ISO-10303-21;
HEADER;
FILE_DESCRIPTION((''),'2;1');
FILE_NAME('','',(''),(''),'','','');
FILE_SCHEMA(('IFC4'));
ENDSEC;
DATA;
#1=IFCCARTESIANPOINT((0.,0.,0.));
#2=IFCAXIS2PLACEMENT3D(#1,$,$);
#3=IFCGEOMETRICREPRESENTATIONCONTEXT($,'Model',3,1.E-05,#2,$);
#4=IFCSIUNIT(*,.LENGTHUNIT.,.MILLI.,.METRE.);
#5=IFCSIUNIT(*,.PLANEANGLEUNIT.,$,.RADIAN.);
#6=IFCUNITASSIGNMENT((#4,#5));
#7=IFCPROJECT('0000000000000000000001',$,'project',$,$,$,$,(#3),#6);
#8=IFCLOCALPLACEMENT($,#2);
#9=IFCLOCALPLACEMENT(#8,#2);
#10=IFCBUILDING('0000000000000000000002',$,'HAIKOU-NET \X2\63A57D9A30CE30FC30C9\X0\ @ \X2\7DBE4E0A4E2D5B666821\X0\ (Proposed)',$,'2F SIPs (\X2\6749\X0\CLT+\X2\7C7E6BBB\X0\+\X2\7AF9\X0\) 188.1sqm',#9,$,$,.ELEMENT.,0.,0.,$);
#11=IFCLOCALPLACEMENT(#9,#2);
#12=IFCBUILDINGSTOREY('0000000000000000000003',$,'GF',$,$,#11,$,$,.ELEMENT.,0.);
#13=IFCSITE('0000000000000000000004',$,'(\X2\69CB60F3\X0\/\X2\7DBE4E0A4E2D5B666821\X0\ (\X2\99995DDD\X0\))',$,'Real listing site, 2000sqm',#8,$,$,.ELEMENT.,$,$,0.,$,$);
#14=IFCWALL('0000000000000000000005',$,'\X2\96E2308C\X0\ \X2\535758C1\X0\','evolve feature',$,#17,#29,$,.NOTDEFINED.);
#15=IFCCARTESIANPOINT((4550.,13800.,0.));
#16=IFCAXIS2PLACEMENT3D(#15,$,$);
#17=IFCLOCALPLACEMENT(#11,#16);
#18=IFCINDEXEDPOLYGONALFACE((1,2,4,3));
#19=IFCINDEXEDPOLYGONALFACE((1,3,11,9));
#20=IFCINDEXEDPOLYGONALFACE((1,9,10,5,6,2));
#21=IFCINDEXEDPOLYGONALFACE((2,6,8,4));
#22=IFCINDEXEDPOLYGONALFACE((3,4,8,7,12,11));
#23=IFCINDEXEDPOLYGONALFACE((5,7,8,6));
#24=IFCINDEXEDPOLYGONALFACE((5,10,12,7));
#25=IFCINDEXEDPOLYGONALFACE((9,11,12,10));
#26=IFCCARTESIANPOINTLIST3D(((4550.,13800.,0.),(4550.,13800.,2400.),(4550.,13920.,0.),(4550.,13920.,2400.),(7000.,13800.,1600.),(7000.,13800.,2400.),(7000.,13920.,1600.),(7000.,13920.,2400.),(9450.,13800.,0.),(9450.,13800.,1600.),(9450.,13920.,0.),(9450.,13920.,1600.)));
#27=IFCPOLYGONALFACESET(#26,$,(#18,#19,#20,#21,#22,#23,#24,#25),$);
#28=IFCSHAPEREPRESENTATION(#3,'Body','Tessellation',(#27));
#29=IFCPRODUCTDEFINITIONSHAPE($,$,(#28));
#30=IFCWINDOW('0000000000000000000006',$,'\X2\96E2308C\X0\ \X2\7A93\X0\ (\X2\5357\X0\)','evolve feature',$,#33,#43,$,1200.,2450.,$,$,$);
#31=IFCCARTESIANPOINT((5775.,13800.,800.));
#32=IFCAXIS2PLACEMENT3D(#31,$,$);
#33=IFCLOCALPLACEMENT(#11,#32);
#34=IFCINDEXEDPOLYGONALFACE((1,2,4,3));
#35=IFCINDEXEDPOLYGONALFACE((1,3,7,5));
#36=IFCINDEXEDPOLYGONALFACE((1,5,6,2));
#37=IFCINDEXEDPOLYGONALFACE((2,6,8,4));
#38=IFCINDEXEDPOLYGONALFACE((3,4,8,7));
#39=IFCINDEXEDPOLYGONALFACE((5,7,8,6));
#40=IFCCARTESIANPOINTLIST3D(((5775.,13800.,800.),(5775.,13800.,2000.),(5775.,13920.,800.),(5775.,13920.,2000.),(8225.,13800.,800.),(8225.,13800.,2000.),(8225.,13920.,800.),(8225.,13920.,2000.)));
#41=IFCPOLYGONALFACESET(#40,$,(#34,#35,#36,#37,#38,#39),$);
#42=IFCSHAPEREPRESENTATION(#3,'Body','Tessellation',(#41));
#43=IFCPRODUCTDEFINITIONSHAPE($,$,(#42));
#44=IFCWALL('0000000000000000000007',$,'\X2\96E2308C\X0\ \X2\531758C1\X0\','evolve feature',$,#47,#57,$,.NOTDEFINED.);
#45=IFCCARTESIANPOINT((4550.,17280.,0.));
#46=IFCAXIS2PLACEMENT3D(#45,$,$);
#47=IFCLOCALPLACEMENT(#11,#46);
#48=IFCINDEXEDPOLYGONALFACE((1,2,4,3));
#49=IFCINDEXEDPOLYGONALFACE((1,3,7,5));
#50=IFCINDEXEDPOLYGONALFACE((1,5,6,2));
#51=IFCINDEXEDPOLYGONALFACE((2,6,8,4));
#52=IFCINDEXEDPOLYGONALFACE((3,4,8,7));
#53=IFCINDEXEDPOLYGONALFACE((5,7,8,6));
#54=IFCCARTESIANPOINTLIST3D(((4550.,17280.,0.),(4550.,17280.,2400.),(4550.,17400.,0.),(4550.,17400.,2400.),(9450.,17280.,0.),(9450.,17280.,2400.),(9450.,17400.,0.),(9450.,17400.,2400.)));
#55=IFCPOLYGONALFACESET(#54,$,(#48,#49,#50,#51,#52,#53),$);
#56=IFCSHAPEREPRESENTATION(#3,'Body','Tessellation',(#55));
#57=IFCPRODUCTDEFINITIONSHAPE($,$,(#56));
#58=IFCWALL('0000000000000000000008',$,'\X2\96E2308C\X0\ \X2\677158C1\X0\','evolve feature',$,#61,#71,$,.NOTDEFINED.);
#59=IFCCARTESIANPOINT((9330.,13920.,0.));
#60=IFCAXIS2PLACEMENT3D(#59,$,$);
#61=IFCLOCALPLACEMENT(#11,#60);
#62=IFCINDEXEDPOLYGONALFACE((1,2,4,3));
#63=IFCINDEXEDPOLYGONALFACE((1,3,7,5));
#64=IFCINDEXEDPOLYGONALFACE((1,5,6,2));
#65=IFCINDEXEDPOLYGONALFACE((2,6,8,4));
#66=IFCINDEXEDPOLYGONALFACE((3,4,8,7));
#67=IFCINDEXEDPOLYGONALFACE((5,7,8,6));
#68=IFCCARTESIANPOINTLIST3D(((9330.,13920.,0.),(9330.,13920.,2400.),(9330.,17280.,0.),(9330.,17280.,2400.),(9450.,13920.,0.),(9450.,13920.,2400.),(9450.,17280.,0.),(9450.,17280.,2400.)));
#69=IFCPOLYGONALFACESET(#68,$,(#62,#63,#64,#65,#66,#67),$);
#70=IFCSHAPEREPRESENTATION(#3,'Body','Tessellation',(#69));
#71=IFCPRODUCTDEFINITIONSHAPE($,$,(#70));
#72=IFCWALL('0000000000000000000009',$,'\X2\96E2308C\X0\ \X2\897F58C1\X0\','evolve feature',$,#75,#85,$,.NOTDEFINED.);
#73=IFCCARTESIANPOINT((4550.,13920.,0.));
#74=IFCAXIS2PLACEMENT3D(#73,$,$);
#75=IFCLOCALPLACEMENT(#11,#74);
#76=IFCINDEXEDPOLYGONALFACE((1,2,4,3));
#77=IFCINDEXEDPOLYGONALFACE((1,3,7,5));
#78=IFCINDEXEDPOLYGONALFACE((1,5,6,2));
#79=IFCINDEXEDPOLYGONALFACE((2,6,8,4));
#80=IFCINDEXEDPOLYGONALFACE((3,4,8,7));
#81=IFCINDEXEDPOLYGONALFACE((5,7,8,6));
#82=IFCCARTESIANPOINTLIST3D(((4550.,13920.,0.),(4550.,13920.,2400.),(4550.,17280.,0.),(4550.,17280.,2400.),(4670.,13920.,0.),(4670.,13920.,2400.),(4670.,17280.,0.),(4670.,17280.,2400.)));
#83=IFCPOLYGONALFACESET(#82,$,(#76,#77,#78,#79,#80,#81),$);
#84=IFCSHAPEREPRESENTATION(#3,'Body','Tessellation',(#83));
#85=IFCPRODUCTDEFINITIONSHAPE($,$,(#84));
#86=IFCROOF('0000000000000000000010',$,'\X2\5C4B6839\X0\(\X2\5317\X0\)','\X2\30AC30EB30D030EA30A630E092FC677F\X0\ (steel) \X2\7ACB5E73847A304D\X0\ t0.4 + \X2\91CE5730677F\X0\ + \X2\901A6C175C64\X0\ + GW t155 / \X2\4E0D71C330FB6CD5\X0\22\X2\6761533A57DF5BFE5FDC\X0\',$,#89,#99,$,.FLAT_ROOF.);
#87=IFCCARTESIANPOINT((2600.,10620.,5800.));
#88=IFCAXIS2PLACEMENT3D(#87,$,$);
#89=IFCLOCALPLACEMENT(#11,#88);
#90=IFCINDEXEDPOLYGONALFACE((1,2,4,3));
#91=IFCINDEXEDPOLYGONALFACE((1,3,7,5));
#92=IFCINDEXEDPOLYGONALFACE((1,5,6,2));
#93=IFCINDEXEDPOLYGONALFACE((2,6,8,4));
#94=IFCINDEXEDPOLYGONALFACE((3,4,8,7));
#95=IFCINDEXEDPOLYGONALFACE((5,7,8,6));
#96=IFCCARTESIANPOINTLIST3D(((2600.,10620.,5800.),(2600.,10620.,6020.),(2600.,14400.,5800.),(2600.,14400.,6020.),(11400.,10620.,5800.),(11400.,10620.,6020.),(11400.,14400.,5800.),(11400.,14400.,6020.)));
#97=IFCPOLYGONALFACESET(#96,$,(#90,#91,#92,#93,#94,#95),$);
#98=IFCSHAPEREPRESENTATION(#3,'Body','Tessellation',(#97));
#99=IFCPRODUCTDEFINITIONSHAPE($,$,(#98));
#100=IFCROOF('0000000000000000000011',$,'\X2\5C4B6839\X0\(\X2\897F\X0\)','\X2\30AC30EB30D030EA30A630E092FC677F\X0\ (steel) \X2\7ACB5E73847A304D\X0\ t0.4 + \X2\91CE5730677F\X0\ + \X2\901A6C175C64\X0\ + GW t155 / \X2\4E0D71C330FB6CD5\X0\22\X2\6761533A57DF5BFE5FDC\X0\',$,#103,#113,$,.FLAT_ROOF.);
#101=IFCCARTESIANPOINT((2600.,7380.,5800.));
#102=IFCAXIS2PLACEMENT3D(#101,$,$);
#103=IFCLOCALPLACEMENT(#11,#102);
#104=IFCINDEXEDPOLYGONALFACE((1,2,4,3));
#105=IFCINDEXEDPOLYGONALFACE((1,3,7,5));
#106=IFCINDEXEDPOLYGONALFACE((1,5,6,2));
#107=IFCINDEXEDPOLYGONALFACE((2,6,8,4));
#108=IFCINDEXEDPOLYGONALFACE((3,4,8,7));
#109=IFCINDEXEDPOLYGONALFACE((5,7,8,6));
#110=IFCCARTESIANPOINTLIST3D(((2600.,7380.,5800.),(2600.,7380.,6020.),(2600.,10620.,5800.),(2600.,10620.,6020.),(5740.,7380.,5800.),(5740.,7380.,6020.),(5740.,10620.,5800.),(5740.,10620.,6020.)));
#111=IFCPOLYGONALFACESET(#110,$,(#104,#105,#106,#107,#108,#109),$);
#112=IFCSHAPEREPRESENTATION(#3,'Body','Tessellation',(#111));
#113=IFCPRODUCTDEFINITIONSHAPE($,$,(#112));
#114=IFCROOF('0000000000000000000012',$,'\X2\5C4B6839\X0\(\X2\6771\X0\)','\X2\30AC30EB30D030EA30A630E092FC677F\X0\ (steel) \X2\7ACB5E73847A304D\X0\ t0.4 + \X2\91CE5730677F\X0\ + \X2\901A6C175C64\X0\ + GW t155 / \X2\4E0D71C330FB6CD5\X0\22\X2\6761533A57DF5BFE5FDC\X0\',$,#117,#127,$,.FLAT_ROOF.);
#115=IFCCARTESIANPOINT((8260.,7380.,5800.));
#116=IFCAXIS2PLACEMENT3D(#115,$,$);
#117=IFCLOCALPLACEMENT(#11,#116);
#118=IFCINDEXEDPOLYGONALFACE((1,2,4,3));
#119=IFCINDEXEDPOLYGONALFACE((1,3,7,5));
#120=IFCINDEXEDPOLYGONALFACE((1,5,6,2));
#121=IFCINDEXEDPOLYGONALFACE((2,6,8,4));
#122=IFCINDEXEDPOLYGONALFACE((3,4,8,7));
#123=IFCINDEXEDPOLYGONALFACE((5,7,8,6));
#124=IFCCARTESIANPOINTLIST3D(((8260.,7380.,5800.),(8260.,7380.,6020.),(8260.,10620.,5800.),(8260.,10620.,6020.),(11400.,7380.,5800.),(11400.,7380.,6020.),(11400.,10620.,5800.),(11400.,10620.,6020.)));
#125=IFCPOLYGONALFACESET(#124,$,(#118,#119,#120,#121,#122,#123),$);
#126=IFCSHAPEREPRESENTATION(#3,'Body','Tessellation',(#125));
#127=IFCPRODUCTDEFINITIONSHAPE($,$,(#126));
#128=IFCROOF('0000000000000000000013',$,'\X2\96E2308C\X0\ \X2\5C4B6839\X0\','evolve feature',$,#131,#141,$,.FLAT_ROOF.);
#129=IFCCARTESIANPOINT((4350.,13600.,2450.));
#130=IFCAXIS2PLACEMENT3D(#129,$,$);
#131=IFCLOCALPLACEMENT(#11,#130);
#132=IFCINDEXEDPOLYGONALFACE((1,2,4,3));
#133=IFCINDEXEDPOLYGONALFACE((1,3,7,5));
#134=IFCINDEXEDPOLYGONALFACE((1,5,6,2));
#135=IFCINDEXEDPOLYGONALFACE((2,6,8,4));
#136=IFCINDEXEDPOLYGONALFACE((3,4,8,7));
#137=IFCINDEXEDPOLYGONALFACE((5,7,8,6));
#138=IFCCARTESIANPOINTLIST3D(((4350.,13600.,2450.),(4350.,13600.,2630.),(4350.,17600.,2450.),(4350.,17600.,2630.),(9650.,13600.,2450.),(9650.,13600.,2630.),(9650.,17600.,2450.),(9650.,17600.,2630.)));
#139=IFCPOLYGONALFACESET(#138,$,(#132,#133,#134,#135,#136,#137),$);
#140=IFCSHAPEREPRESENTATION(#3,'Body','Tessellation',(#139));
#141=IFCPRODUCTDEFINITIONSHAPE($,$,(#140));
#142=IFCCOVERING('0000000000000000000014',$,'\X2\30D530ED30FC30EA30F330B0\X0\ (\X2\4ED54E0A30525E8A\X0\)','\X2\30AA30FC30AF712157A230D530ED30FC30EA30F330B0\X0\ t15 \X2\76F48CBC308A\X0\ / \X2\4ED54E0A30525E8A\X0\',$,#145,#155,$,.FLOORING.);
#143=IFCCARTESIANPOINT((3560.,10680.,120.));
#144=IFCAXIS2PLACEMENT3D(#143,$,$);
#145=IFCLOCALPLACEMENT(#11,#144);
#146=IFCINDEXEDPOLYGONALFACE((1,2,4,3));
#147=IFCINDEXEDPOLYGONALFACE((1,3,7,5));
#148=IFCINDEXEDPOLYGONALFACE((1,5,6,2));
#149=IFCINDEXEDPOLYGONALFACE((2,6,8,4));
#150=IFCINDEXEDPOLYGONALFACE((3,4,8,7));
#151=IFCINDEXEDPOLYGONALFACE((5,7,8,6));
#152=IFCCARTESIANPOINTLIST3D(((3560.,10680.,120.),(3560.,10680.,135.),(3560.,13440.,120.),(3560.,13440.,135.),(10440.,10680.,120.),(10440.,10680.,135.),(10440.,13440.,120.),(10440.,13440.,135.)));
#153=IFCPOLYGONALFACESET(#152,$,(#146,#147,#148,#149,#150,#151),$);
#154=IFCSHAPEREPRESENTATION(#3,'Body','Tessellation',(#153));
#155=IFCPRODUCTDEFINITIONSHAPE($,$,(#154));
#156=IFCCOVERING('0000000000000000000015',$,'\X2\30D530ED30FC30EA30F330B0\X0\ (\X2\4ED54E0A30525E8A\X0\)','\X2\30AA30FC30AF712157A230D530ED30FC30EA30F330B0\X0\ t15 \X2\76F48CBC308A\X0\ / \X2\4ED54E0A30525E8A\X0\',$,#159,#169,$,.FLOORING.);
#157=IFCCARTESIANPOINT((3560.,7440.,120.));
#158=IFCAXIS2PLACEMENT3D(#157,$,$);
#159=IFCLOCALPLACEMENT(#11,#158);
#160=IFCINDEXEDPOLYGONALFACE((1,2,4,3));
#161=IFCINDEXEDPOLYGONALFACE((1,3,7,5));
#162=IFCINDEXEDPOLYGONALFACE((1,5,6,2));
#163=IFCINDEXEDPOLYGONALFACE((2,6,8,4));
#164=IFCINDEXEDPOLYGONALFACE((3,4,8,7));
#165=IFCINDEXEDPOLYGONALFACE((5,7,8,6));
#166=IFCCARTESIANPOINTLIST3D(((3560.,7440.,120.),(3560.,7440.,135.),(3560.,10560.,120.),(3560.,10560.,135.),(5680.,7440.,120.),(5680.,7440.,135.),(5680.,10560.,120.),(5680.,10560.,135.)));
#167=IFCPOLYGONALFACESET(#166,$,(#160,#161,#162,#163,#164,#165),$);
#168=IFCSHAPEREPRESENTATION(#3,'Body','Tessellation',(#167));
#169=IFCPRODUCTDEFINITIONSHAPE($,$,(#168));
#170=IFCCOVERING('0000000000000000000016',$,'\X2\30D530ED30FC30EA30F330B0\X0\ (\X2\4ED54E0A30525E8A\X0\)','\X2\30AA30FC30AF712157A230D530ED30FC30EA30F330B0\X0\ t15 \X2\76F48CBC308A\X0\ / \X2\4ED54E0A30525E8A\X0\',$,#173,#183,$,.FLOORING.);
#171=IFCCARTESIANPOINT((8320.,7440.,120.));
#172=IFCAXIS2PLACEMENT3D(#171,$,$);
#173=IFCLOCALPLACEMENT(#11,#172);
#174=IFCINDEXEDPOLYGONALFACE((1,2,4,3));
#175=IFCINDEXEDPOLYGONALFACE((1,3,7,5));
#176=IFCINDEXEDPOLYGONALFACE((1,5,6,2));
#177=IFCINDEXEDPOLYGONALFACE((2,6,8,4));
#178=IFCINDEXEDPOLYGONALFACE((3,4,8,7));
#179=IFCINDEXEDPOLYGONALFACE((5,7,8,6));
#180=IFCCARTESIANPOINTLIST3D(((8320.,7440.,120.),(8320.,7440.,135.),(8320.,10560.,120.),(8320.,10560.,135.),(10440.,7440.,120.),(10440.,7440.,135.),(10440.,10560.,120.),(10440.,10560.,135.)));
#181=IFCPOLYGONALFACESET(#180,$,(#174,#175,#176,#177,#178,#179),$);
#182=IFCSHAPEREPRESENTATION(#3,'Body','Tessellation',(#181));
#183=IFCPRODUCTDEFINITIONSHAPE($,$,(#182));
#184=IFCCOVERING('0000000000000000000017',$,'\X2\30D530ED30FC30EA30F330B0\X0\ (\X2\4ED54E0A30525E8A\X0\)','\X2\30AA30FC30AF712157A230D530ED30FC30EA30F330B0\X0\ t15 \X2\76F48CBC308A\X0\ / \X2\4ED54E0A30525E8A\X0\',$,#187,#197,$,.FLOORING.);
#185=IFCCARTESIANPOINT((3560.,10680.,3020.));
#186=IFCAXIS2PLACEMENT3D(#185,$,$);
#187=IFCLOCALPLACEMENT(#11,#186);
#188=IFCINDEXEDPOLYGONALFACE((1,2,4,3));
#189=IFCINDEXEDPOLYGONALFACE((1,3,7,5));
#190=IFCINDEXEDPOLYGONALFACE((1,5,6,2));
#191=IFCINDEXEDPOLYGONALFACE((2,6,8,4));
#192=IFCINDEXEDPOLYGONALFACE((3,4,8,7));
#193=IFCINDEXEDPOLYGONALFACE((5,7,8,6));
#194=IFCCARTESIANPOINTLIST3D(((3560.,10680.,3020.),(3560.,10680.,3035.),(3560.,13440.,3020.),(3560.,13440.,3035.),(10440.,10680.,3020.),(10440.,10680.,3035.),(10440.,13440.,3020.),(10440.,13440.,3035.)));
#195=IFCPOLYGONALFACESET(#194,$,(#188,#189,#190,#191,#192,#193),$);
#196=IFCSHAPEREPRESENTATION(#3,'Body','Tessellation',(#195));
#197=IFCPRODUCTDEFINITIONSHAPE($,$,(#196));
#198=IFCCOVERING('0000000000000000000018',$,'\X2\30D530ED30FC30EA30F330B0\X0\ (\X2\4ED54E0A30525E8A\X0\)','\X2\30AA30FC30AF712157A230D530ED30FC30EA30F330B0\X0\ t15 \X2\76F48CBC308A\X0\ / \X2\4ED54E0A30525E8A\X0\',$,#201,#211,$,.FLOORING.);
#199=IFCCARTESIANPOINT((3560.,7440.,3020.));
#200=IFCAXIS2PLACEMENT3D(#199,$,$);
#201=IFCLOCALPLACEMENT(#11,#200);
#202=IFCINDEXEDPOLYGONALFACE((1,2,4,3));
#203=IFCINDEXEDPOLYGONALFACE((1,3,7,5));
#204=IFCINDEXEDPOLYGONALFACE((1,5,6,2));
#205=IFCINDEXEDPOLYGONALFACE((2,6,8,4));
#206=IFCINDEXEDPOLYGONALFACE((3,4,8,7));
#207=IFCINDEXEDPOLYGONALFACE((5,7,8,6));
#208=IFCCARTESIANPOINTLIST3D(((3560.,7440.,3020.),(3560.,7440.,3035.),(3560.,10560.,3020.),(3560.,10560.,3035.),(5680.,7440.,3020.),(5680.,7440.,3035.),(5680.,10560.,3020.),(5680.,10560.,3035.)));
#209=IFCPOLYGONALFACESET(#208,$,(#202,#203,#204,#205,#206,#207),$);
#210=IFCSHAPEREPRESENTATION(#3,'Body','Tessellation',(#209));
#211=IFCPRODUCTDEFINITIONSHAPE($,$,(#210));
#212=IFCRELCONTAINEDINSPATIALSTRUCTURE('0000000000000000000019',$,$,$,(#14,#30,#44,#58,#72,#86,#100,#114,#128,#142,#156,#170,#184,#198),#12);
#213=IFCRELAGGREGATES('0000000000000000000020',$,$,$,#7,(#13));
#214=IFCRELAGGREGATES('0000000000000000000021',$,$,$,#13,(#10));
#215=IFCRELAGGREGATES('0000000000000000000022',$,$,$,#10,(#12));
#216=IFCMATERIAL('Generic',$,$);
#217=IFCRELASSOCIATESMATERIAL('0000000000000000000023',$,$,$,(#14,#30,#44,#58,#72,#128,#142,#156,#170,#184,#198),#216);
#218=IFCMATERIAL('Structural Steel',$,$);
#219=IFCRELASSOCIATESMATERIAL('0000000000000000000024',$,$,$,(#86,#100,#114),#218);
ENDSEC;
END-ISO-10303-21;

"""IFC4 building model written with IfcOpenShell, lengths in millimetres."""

from ifc_helpers import new_model, si_unit, frame, frame_2d, origin, place, context, project, spatial, rectangle, extrude, material, element, fill, save


model = new_model("IFC4")

# Units and contexts
model_context = context("Model", 3, precision=1e-05, world=origin())
ifc_project = project(units=[si_unit("LENGTHUNIT", "METRE", prefix="MILLI"), si_unit("PLANEANGLEUNIT", "RADIAN")], contexts=[model_context])

# Site, building, storey
site_placement = place(None, origin())
site = spatial("IfcSite", under=ifc_project, at=site_placement, Name="(構想/綾上中学校 (香川))", ObjectType="Real listing site, 2000sqm", CompositionType="ELEMENT", RefElevation=0.0)
building_placement = place(site_placement, origin())
building = spatial("IfcBuilding", under=site, at=building_placement, Name="HAIKOU-NET 接続ノード @ 綾上中学校 (Proposed)", ObjectType="2F SIPs (杉CLT+籾殻+竹) 188.1sqm", CompositionType="ELEMENT", ElevationOfRefHeight=0.0, ElevationOfTerrain=0.0)
storey_placement = place(building_placement, origin())
storey = spatial("IfcBuildingStorey", under=building, at=storey_placement, Name="GF", CompositionType="ELEMENT", Elevation=0.0)

# Shared definitions
ifc_material_1 = material(Name="Generic")

# Wall, opening, window
wall_1_placement = place(storey_placement, frame((4550.0, 13800.0, 0.0)))
wall_1 = element("IfcWall", 1, at=wall_1_placement, inside=storey, material=ifc_material_1, Name="離れ 南壁", Description="evolve feature", PredefinedType="NOTDEFINED", context=model_context, shape_type="SweptSolid", body=[
    extrude(rectangle(XDim=4900.0, YDim=120.0, at=frame_2d((2450.0, 60.0))), frame((4550.0, 13800.0, 0.0)), (0.0, 0.0, 1.0), 2400.0),
])
opening_1_placement = place(storey_placement, frame((5775.0, 13800.0, 800.0)))
opening_1 = element("IfcOpeningElement", 2, at=opening_1_placement, cuts=wall_1, PredefinedType="NOTDEFINED", context=model_context, shape_type="SweptSolid", body=[
    extrude(rectangle(XDim=2450.0, YDim=120.0, at=frame_2d((1225.0, 60.0))), frame((5775.0, 13800.0, 800.0)), (0.0, 0.0, 1.0), 1200.0),
])
window_1_placement = place(storey_placement, frame((5775.0, 13800.0, 800.0)))
window_1 = element("IfcWindow", 3, at=window_1_placement, inside=storey, material=ifc_material_1, Name="離れ 窓 (南)", Description="evolve feature", OverallHeight=1200.0, OverallWidth=2450.0, context=model_context, shape_type="SweptSolid", body=[
    extrude(rectangle(XDim=2450.0, YDim=120.0, at=frame_2d((1225.0, 60.0))), frame((5775.0, 13800.0, 800.0)), (0.0, 0.0, 1.0), 1200.0),
])
fill(opening_1, window_1)

# Walls
wall_2_placement = place(storey_placement, frame((4550.0, 17280.0, 0.0)))
element("IfcWall", 4, at=wall_2_placement, inside=storey, material=ifc_material_1, Name="離れ 北壁", Description="evolve feature", PredefinedType="NOTDEFINED", context=model_context, shape_type="SweptSolid", body=[
    extrude(rectangle(XDim=4900.0, YDim=120.0, at=frame_2d((2450.0, 60.0))), frame((4550.0, 17280.0, 0.0)), (0.0, 0.0, 1.0), 2400.0),
])
wall_3_placement = place(storey_placement, frame((9330.0, 13920.0, 0.0)))
element("IfcWall", 5, at=wall_3_placement, inside=storey, material=ifc_material_1, Name="離れ 東壁", Description="evolve feature", PredefinedType="NOTDEFINED", context=model_context, shape_type="SweptSolid", body=[
    extrude(rectangle(XDim=120.0, YDim=3360.0, at=frame_2d((60.0, 1680.0))), frame((9330.0, 13920.0, 0.0)), (0.0, 0.0, 1.0), 2400.0),
])
wall_4_placement = place(storey_placement, frame((4550.0, 13920.0, 0.0)))
element("IfcWall", 6, at=wall_4_placement, inside=storey, material=ifc_material_1, Name="離れ 西壁", Description="evolve feature", PredefinedType="NOTDEFINED", context=model_context, shape_type="SweptSolid", body=[
    extrude(rectangle(XDim=120.0, YDim=3360.0, at=frame_2d((60.0, 1680.0))), frame((4550.0, 13920.0, 0.0)), (0.0, 0.0, 1.0), 2400.0),
])

# Roofs
ifc_material_2 = material(Name="Structural Steel")
for number, where, name in (
    (7, (2600.0, 10620.0, 5800.0), "屋根(北)"),
):
    element("IfcRoof", number, at=place(storey_placement, frame(where)), inside=storey, material=ifc_material_2, Name=name, Description="ガルバリウム鋼板 (steel) 立平葺き t0.4 + 野地板 + 通気層 + GW t155 / 不燃・法22条区域対応", PredefinedType="FLAT_ROOF", context=model_context, shape_type="SweptSolid", body=[
        extrude(rectangle(XDim=8800.0, YDim=3780.0, at=frame_2d((4400.0, 1890.0))), frame((2600.0, 10620.0, 5800.0)), (0.0, 0.0, 1.0), 220.0),
    ])
roof_1_placement = place(storey_placement, frame((2600.0, 7380.0, 5800.0)))
element("IfcRoof", 8, at=roof_1_placement, inside=storey, material=ifc_material_2, Name="屋根(西)", Description="ガルバリウム鋼板 (steel) 立平葺き t0.4 + 野地板 + 通気層 + GW t155 / 不燃・法22条区域対応", PredefinedType="FLAT_ROOF", context=model_context, shape_type="SweptSolid", body=[
    extrude(rectangle(XDim=3140.0, YDim=3240.0, at=frame_2d((1570.0, 1620.0))), frame((2600.0, 7380.0, 5800.0)), (0.0, 0.0, 1.0), 220.0),
])
roof_2_placement = place(storey_placement, frame((8260.0, 7380.0, 5800.0)))
element("IfcRoof", 9, at=roof_2_placement, inside=storey, material=ifc_material_2, Name="屋根(東)", Description="ガルバリウム鋼板 (steel) 立平葺き t0.4 + 野地板 + 通気層 + GW t155 / 不燃・法22条区域対応", PredefinedType="FLAT_ROOF", context=model_context, shape_type="SweptSolid", body=[
    extrude(rectangle(XDim=3140.0, YDim=3240.0, at=frame_2d((1570.0, 1620.0))), frame((8260.0, 7380.0, 5800.0)), (0.0, 0.0, 1.0), 220.0),
])
roof_3_placement = place(storey_placement, frame((4350.0, 13600.0, 2450.0)))
element("IfcRoof", 10, at=roof_3_placement, inside=storey, material=ifc_material_1, Name="離れ 屋根", Description="evolve feature", PredefinedType="FLAT_ROOF", context=model_context, shape_type="SweptSolid", body=[
    extrude(rectangle(XDim=5300.0, YDim=4000.0, at=frame_2d((2650.0, 2000.0))), frame((4350.0, 13600.0, 2450.0)), (0.0, 0.0, 1.0), 180.0),
])

# Coverings
covering_1_placement = place(storey_placement, frame((3560.0, 10680.0, 120.0)))
element("IfcCovering", 11, at=covering_1_placement, inside=storey, material=ifc_material_1, Name="フローリング (仕上げ床)", Description="オーク無垢フローリング t15 直貼り / 仕上げ床", PredefinedType="FLOORING", context=model_context, shape_type="SweptSolid", body=[
    extrude(rectangle(XDim=6880.0, YDim=2760.0, at=frame_2d((3440.0, 1380.0))), frame((3560.0, 10680.0, 120.0)), (0.0, 0.0, 1.0), 15.0),
])
covering_2_placement = place(storey_placement, frame((3560.0, 7440.0, 120.0)))
element("IfcCovering", 12, at=covering_2_placement, inside=storey, material=ifc_material_1, Name="フローリング (仕上げ床)", Description="オーク無垢フローリング t15 直貼り / 仕上げ床", PredefinedType="FLOORING", context=model_context, shape_type="SweptSolid", body=[
    extrude(rectangle(XDim=2120.0, YDim=3120.0, at=frame_2d((1060.0, 1560.0))), frame((3560.0, 7440.0, 120.0)), (0.0, 0.0, 1.0), 15.0),
])
covering_3_placement = place(storey_placement, frame((8320.0, 7440.0, 120.0)))
element("IfcCovering", 13, at=covering_3_placement, inside=storey, material=ifc_material_1, Name="フローリング (仕上げ床)", Description="オーク無垢フローリング t15 直貼り / 仕上げ床", PredefinedType="FLOORING", context=model_context, shape_type="SweptSolid", body=[
    extrude(rectangle(XDim=2120.0, YDim=3120.0, at=frame_2d((1060.0, 1560.0))), frame((8320.0, 7440.0, 120.0)), (0.0, 0.0, 1.0), 15.0),
])
covering_4_placement = place(storey_placement, frame((3560.0, 10680.0, 3020.0)))
element("IfcCovering", 14, at=covering_4_placement, inside=storey, material=ifc_material_1, Name="フローリング (仕上げ床)", Description="オーク無垢フローリング t15 直貼り / 仕上げ床", PredefinedType="FLOORING", context=model_context, shape_type="SweptSolid", body=[
    extrude(rectangle(XDim=6880.0, YDim=2760.0, at=frame_2d((3440.0, 1380.0))), frame((3560.0, 10680.0, 3020.0)), (0.0, 0.0, 1.0), 15.0),
])
covering_5_placement = place(storey_placement, frame((3560.0, 7440.0, 3020.0)))
element("IfcCovering", 15, at=covering_5_placement, inside=storey, material=ifc_material_1, Name="フローリング (仕上げ床)", Description="オーク無垢フローリング t15 直貼り / 仕上げ床", PredefinedType="FLOORING", context=model_context, shape_type="SweptSolid", body=[
    extrude(rectangle(XDim=2120.0, YDim=3120.0, at=frame_2d((1060.0, 1560.0))), frame((3560.0, 7440.0, 3020.0)), (0.0, 0.0, 1.0), 15.0),
])

save(model, "model.ifc")
